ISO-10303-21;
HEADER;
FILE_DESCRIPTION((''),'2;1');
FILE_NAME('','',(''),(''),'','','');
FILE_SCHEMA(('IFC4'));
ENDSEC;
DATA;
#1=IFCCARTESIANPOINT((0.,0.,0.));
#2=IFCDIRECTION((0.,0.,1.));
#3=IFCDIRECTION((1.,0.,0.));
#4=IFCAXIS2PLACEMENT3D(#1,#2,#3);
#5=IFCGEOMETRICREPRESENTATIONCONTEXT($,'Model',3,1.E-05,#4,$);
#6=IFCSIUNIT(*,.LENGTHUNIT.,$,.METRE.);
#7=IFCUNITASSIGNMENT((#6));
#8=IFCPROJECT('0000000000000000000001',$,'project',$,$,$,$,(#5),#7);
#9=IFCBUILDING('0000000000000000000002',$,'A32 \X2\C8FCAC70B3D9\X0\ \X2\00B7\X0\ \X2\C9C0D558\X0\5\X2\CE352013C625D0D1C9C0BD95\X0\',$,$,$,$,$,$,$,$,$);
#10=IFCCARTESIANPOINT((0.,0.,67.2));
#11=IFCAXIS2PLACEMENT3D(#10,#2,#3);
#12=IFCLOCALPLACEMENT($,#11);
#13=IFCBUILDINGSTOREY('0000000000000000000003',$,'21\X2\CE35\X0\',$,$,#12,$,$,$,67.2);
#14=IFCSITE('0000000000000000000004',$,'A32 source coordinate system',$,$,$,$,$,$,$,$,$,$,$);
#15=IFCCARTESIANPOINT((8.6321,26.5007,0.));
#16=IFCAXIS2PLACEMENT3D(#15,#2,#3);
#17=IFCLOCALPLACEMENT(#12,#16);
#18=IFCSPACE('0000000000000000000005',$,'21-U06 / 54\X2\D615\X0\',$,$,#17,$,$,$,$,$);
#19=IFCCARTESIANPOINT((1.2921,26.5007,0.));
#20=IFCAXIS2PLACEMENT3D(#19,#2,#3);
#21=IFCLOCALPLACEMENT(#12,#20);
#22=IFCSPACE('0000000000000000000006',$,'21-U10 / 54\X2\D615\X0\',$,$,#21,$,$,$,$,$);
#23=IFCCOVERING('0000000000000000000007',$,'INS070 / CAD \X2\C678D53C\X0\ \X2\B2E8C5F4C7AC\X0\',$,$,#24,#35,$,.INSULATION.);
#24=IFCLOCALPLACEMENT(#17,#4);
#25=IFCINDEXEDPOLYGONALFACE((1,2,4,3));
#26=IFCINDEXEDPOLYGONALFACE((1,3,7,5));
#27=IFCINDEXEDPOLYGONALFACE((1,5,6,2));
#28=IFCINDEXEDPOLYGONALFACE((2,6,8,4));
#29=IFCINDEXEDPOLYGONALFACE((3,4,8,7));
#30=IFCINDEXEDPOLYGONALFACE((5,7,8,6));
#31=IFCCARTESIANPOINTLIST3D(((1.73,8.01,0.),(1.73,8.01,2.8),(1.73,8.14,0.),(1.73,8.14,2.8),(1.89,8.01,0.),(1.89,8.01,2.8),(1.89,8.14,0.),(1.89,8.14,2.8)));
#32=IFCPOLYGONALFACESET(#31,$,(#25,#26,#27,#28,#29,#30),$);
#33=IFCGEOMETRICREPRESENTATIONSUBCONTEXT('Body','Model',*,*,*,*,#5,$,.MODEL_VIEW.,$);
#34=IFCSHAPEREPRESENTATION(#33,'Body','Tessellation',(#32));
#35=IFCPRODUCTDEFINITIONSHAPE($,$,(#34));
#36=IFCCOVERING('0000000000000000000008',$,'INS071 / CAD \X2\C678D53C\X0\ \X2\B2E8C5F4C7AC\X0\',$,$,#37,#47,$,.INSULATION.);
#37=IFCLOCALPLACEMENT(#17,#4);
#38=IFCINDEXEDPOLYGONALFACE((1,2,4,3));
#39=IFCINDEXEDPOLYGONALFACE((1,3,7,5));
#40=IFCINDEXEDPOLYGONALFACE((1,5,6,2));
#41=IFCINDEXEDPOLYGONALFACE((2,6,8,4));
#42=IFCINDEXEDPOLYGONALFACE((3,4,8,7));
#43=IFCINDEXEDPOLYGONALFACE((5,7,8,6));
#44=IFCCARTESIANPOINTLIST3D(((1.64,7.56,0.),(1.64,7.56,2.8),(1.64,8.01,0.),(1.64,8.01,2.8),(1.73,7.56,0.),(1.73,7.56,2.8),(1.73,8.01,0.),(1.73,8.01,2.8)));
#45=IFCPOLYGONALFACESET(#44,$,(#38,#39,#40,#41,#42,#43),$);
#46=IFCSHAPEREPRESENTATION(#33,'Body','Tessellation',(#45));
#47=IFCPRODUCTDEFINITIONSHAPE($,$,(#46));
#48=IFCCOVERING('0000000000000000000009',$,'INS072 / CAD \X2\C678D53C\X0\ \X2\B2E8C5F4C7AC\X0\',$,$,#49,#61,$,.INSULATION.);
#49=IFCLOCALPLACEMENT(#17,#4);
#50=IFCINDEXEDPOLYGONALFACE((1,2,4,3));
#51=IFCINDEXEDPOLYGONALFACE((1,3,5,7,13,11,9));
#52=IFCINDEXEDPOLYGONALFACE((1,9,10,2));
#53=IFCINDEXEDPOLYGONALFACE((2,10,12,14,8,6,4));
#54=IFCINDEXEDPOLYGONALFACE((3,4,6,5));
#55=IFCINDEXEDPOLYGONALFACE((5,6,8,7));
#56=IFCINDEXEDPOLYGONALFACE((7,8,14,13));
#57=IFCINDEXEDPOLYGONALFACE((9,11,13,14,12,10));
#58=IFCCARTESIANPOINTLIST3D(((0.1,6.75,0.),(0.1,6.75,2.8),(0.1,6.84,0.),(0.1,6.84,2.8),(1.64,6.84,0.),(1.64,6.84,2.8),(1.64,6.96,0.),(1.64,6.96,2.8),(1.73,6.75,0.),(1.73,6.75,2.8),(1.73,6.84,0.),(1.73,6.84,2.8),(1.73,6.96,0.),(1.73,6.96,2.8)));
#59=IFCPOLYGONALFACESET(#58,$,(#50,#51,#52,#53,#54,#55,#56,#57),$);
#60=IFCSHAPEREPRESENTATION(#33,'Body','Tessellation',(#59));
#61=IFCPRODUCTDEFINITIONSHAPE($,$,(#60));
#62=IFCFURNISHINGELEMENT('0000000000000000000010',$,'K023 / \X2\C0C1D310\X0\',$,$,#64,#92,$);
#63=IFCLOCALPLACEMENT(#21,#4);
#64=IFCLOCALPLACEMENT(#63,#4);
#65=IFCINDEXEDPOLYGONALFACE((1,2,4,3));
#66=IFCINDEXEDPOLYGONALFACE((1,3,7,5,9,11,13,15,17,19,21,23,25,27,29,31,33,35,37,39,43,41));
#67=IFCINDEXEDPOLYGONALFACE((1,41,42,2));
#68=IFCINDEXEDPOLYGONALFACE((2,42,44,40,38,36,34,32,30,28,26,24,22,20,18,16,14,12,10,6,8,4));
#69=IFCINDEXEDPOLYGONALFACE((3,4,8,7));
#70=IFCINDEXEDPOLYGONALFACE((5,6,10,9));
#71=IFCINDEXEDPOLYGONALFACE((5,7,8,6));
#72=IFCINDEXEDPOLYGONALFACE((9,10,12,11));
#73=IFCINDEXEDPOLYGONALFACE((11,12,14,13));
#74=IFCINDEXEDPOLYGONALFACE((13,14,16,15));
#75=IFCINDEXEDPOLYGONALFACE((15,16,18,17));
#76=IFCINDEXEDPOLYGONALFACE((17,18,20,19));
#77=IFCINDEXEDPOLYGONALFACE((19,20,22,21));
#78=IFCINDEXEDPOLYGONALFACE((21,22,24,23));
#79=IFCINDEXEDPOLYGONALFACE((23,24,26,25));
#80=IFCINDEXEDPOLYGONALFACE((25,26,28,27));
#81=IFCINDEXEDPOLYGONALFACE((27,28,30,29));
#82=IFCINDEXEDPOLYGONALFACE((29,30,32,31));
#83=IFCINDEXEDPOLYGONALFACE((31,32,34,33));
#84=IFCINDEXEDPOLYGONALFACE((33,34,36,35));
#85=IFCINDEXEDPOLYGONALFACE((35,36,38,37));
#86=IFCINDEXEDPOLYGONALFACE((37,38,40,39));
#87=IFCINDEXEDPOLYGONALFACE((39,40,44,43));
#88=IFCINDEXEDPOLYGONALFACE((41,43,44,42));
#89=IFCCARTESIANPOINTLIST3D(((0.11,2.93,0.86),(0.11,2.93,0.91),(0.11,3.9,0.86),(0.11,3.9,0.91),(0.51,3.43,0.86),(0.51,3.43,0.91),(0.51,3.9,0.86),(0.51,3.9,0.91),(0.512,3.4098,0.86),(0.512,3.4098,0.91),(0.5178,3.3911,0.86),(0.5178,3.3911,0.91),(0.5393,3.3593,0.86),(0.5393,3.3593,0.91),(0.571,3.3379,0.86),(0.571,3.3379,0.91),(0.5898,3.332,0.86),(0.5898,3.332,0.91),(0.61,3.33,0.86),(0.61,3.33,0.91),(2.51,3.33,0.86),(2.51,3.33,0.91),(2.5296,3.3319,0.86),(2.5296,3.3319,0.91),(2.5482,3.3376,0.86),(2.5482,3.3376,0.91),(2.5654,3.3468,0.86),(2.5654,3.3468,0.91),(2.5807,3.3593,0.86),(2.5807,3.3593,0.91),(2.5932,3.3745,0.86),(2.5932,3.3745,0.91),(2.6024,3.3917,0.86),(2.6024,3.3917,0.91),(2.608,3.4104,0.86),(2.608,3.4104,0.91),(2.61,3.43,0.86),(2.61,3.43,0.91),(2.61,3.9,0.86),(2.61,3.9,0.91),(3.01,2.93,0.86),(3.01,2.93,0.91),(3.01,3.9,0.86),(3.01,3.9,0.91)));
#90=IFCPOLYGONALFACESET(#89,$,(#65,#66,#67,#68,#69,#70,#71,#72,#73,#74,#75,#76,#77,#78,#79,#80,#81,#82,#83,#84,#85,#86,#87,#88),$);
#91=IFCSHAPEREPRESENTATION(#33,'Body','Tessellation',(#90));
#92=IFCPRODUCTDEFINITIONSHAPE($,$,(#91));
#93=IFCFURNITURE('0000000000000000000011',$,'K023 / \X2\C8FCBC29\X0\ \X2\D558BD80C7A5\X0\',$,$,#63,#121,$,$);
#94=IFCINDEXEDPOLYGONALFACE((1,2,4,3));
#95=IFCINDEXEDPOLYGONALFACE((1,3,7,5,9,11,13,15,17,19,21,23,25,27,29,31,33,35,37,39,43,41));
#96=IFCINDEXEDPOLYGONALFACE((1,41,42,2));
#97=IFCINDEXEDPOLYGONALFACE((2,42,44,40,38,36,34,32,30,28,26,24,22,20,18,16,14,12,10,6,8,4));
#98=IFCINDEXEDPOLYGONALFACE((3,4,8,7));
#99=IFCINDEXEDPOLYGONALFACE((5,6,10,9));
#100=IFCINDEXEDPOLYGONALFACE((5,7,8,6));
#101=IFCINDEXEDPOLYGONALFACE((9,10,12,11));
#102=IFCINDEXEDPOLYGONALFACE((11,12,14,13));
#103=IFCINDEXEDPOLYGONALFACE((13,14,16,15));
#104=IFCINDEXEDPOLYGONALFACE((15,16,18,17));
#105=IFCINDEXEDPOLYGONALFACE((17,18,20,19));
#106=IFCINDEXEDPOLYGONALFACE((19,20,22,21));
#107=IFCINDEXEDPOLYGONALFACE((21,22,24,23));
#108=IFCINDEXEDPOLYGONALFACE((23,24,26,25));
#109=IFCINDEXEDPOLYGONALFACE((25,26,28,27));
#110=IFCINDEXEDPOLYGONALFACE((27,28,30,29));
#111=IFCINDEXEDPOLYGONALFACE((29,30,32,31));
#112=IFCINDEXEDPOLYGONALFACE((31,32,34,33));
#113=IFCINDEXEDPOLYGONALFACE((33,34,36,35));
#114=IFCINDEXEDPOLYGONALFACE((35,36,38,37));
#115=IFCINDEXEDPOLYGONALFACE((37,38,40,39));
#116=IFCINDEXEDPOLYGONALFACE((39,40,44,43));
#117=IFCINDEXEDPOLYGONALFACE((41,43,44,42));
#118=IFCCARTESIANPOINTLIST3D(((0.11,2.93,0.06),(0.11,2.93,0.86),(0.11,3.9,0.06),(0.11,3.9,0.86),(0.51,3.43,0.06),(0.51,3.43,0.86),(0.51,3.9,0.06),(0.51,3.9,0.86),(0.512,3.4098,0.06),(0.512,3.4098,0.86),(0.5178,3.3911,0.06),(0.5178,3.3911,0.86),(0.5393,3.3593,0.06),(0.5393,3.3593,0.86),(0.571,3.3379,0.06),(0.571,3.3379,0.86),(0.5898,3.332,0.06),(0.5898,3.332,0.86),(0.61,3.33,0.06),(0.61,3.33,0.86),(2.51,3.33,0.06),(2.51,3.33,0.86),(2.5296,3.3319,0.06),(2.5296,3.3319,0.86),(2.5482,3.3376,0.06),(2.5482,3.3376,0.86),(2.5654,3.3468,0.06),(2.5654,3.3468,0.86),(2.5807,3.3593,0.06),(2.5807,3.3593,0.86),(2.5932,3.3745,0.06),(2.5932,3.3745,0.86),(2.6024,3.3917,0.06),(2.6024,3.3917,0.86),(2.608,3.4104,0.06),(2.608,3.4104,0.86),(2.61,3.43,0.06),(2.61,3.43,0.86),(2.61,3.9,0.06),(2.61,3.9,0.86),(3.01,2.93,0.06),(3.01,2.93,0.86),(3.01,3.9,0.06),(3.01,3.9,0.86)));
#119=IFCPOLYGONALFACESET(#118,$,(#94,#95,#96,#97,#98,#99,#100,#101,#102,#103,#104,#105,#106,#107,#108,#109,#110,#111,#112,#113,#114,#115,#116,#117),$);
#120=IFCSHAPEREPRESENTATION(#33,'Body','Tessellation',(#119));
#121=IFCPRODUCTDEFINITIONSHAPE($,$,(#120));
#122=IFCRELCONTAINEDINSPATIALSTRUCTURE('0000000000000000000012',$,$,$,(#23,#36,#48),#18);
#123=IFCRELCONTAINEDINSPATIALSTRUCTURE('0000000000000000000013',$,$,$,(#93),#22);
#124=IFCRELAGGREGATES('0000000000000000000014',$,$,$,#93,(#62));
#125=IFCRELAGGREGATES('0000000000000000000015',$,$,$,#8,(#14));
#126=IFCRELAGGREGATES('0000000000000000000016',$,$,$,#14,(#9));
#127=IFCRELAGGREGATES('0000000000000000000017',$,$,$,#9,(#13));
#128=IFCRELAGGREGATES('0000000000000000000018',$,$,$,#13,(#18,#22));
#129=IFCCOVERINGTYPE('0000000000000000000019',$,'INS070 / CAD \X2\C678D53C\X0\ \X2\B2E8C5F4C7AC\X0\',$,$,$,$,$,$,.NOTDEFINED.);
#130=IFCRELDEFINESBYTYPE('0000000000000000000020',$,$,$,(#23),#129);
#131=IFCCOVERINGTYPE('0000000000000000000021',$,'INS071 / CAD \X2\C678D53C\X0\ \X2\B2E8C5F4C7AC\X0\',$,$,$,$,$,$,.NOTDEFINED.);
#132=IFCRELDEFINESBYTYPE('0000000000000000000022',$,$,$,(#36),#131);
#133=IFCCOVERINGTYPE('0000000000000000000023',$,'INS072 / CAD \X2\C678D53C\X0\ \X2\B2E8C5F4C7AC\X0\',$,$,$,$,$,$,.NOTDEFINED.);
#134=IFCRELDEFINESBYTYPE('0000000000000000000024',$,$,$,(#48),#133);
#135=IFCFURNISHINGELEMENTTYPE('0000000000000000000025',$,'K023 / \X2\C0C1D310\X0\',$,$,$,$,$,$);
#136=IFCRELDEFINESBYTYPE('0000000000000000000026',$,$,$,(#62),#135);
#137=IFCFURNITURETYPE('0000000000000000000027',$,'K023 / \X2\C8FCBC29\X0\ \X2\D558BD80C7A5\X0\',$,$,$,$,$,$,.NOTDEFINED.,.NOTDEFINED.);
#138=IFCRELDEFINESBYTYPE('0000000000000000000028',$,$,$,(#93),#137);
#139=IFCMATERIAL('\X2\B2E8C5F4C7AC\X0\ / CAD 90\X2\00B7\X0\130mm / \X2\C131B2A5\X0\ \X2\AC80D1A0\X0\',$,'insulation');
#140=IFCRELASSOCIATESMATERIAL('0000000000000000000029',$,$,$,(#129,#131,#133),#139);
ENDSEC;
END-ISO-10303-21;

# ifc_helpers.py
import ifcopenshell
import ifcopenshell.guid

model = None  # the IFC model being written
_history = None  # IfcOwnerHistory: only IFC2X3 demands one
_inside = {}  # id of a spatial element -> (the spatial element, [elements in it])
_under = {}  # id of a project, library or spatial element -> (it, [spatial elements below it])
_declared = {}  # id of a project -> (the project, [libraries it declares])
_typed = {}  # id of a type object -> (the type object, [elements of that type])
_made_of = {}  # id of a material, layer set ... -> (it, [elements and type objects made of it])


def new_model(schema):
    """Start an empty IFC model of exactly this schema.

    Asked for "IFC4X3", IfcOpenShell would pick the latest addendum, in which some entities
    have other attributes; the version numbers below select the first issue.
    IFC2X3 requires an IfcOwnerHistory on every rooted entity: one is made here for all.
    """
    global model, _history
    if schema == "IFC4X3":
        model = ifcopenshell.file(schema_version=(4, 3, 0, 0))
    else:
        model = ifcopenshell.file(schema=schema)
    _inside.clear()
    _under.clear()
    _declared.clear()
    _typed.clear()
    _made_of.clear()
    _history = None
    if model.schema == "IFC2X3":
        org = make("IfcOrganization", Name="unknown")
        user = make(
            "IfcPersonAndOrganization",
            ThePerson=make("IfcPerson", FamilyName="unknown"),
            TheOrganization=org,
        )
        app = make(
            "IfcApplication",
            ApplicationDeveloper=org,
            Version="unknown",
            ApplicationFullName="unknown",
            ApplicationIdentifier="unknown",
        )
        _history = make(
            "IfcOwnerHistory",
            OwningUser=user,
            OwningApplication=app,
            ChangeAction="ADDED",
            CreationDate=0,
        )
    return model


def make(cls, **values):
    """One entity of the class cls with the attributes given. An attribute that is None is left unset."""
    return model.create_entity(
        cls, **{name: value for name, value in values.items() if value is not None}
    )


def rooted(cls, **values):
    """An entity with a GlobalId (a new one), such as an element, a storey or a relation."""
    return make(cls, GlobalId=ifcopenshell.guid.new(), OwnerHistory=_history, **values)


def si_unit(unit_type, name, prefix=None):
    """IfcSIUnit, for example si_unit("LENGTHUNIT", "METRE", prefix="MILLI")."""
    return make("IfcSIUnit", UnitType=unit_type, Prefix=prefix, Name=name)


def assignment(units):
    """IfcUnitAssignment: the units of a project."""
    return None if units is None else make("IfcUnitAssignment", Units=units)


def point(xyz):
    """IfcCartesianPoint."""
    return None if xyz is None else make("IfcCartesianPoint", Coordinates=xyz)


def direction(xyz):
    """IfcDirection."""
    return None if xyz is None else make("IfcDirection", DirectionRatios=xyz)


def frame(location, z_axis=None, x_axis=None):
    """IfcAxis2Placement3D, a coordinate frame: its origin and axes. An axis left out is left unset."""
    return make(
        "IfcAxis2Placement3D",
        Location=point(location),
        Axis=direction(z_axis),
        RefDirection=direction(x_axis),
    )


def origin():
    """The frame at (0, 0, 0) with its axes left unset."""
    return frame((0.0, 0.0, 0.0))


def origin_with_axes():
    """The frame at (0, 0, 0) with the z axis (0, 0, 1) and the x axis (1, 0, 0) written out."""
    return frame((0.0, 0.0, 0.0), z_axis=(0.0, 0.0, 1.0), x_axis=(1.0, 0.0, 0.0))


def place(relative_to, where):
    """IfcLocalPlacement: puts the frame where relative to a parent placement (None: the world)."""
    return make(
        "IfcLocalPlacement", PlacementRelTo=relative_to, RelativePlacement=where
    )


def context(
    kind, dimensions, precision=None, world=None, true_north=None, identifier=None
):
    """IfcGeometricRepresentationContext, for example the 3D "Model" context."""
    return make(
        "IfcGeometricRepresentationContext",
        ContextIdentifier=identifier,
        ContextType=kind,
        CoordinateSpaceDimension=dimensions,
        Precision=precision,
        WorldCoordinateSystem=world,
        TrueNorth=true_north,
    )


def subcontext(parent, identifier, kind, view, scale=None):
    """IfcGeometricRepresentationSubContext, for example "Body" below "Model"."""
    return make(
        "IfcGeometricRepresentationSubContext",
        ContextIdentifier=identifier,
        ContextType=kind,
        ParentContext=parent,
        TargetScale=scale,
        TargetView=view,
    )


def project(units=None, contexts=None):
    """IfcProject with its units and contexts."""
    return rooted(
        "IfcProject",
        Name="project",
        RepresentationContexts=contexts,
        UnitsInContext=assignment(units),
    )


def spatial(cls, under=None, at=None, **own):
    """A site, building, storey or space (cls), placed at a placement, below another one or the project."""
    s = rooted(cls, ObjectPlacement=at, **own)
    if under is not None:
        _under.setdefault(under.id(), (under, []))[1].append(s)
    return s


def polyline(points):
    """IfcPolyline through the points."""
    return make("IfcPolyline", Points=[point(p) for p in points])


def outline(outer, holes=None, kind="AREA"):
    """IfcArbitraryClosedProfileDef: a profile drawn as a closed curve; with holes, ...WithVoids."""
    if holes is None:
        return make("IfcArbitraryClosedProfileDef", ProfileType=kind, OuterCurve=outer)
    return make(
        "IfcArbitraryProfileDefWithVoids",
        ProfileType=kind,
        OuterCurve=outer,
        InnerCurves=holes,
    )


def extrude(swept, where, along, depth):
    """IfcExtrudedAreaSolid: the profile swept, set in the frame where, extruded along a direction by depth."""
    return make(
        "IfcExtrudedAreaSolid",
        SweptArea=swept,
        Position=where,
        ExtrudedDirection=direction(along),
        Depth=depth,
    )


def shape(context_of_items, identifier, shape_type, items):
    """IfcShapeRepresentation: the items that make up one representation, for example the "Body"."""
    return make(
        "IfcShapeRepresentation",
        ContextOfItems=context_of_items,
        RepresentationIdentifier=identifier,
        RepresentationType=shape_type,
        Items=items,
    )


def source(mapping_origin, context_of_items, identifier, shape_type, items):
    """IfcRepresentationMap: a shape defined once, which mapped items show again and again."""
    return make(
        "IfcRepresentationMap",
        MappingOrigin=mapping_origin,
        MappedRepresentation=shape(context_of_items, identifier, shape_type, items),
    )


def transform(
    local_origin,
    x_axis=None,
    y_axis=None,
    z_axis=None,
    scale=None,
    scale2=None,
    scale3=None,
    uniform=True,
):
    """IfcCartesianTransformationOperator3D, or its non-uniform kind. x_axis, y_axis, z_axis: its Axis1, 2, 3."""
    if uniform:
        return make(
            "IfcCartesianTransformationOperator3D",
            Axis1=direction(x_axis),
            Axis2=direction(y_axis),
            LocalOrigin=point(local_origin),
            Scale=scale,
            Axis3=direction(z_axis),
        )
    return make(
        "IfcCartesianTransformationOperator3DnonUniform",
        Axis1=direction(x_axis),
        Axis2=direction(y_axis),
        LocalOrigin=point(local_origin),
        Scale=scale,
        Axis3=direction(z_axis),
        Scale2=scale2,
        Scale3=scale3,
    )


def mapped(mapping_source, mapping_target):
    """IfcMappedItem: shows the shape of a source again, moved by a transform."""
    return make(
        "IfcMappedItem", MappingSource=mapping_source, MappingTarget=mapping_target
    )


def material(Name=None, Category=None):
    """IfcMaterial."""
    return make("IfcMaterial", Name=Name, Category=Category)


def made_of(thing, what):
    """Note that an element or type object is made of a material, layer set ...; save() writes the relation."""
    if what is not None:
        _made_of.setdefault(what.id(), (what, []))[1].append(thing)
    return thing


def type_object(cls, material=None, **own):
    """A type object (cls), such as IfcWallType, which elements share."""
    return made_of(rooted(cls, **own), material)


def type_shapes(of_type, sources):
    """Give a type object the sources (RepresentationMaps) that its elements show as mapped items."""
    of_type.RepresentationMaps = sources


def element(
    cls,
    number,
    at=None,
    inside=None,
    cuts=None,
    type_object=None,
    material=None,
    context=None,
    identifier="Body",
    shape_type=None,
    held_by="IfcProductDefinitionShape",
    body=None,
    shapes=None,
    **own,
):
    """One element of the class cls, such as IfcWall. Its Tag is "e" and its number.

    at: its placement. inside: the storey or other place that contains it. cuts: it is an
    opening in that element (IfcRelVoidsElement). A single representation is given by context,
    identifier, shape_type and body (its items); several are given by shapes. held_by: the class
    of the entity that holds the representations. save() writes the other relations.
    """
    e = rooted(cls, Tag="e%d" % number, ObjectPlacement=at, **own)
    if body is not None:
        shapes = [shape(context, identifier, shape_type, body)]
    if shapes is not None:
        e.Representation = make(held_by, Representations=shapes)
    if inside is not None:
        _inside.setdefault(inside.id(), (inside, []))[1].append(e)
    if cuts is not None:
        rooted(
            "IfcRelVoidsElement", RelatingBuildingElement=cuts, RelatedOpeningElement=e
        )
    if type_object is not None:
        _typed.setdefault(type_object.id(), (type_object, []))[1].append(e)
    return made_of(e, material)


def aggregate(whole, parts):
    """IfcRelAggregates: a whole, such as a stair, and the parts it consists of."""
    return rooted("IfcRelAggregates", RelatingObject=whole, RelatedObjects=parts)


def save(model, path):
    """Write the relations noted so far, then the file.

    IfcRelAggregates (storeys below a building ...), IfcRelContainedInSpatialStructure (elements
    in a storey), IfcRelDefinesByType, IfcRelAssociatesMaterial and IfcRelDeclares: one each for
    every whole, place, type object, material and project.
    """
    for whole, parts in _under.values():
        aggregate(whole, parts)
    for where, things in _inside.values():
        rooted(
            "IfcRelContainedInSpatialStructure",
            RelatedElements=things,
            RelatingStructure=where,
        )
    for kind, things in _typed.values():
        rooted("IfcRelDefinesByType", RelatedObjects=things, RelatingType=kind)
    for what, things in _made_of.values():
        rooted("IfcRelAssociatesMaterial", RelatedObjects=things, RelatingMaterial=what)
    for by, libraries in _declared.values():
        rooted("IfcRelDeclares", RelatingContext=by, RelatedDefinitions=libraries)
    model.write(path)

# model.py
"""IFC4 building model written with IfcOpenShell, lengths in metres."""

from ifc_helpers import new_model, si_unit, frame, origin, origin_with_axes, place, context, subcontext, project, spatial, polyline, outline, extrude, source, transform, mapped, material, type_object, type_shapes, element, aggregate, save


model = new_model("IFC4")

# Units and contexts
model_context = context("Model", 3, precision=1e-05, world=origin_with_axes())
body_context = subcontext(model_context, "Body", "Model", "MODEL_VIEW")
ifc_project = project(units=[si_unit("LENGTHUNIT", "METRE")], contexts=[model_context])

# Site, building, storey, space
storey_placement = place(None, frame((0.0, 0.0, 67.2), z_axis=(0.0, 0.0, 1.0), x_axis=(1.0, 0.0, 0.0)))
space_1_placement = place(storey_placement, frame((8.6321, 26.5007, 0.0), z_axis=(0.0, 0.0, 1.0), x_axis=(1.0, 0.0, 0.0)))
site = spatial("IfcSite", under=ifc_project, Name="A32 source coordinate system")
building = spatial("IfcBuilding", under=site, Name="A32 주거동 · 지하5층–옥탑지붕")
storey = spatial("IfcBuildingStorey", under=building, at=storey_placement, Name="21층", Elevation=67.2)
space_1 = spatial("IfcSpace", under=storey, at=space_1_placement, Name="21-U06 / 54형")

# Coverings
ifc_material = material(Name="단열재 / CAD 90·130mm / 성능 검토", Category="insulation")
covering_type_1 = type_object("IfcCoveringType", Name="INS070 / CAD 외피 단열재", PredefinedType="NOTDEFINED", material=ifc_material)
shared_shape_1 = source(origin(), body_context, "Body", "SweptSolid", [
    extrude(outline(polyline([(1.73, 8.14), (1.89, 8.14), (1.89, 8.01), (1.73, 8.01), (1.73, 8.14)])), origin(), (0.0, 0.0, 1.0), 2.8),
])
type_shapes(covering_type_1, [shared_shape_1])
covering_1_placement = place(space_1_placement, origin_with_axes())
element("IfcCovering", 1, at=covering_1_placement, inside=space_1, type_object=covering_type_1, Name="INS070 / CAD 외피 단열재", PredefinedType="INSULATION", context=body_context, shape_type="MappedRepresentation", body=[
    mapped(shared_shape_1, transform((0.0, 0.0, 0.0), scale=1.0)),
])
covering_type_2 = type_object("IfcCoveringType", Name="INS071 / CAD 외피 단열재", PredefinedType="NOTDEFINED", material=ifc_material)
shared_shape_2 = source(origin(), body_context, "Body", "SweptSolid", [
    extrude(outline(polyline([(1.73, 7.56), (1.64, 7.56), (1.64, 8.01), (1.73, 8.01), (1.73, 7.56)])), origin(), (0.0, 0.0, 1.0), 2.8),
])
type_shapes(covering_type_2, [shared_shape_2])
covering_2_placement = place(space_1_placement, origin_with_axes())
element("IfcCovering", 2, at=covering_2_placement, inside=space_1, type_object=covering_type_2, Name="INS071 / CAD 외피 단열재", PredefinedType="INSULATION", context=body_context, shape_type="MappedRepresentation", body=[
    mapped(shared_shape_2, transform((0.0, 0.0, 0.0), scale=1.0)),
])
covering_type_3 = type_object("IfcCoveringType", Name="INS072 / CAD 외피 단열재", PredefinedType="NOTDEFINED", material=ifc_material)
shared_shape_3 = source(origin(), body_context, "Body", "SweptSolid", [
    extrude(outline(polyline([(1.64, 6.84), (1.64, 6.96), (1.73, 6.96), (1.73, 6.84), (1.73, 6.75), (0.1, 6.75), (0.1, 6.84), (1.64, 6.84)])), origin(), (0.0, 0.0, 1.0), 2.8),
])
type_shapes(covering_type_3, [shared_shape_3])
covering_3_placement = place(space_1_placement, origin_with_axes())
element("IfcCovering", 3, at=covering_3_placement, inside=space_1, type_object=covering_type_3, Name="INS072 / CAD 외피 단열재", PredefinedType="INSULATION", context=body_context, shape_type="MappedRepresentation", body=[
    mapped(shared_shape_3, transform((0.0, 0.0, 0.0), scale=1.0)),
])

# Shared definitions
space_2_placement = place(storey_placement, frame((1.2921, 26.5007, 0.0), z_axis=(0.0, 0.0, 1.0), x_axis=(1.0, 0.0, 0.0)))

# Furnishing element
furnishing_element_type_1 = type_object("IfcFurnishingElementType", Name="K023 / 상판")
shared_shape_4 = source(origin(), body_context, "Body", "SweptSolid", [
    extrude(outline(polyline([(0.51, 3.43), (0.512, 3.4098), (0.5178, 3.3911), (0.5393, 3.3593), (0.571, 3.3379), (0.5898, 3.332), (0.61, 3.33), (2.51, 3.33), (2.5296, 3.3319), (2.5482, 3.3376), (2.5654, 3.3468), (2.5807, 3.3593), (2.5932, 3.3745), (2.6024, 3.3917), (2.608, 3.4104), (2.61, 3.43), (2.61, 3.9), (3.01, 3.9), (3.01, 2.93), (0.11, 2.93), (0.11, 3.9), (0.51, 3.9), (0.51, 3.43)])), frame((0.0, 0.0, 0.86)), (0.0, 0.0, 1.0), 0.05),
])
type_shapes(furnishing_element_type_1, [shared_shape_4])
furniture_1_placement = place(space_2_placement, origin_with_axes())
furnishing_1_placement = place(furniture_1_placement, origin_with_axes())
furnishing_1 = element("IfcFurnishingElement", 4, at=furnishing_1_placement, type_object=furnishing_element_type_1, Name="K023 / 상판", context=body_context, shape_type="MappedRepresentation", body=[
    mapped(shared_shape_4, transform((0.0, 0.0, 0.0), scale=1.0)),
])

# Shared definitions
space_2 = spatial("IfcSpace", under=storey, at=space_2_placement, Name="21-U10 / 54형")

# Furniture
furniture_type_1 = type_object("IfcFurnitureType", Name="K023 / 주방 하부장", AssemblyPlace="NOTDEFINED", PredefinedType="NOTDEFINED")
shared_shape_5 = source(origin(), body_context, "Body", "SweptSolid", [
    extrude(outline(polyline([(0.51, 3.9), (0.51, 3.43), (0.512, 3.4098), (0.5178, 3.3911), (0.5393, 3.3593), (0.571, 3.3379), (0.5898, 3.332), (0.61, 3.33), (2.51, 3.33), (2.5296, 3.3319), (2.5482, 3.3376), (2.5654, 3.3468), (2.5807, 3.3593), (2.5932, 3.3745), (2.6024, 3.3917), (2.608, 3.4104), (2.61, 3.43), (2.61, 3.9), (3.01, 3.9), (3.01, 2.93), (0.11, 2.93), (0.11, 3.9), (0.51, 3.9)])), frame((0.0, 0.0, 0.06)), (0.0, 0.0, 1.0), 0.8),
])
type_shapes(furniture_type_1, [shared_shape_5])
furniture_1 = element("IfcFurniture", 5, at=furniture_1_placement, inside=space_2, type_object=furniture_type_1, Name="K023 / 주방 하부장", context=body_context, shape_type="MappedRepresentation", body=[
    mapped(shared_shape_5, transform((0.0, 0.0, 0.0), scale=1.0)),
])
aggregate(furniture_1, [furnishing_1])

save(model, "model.ifc")
